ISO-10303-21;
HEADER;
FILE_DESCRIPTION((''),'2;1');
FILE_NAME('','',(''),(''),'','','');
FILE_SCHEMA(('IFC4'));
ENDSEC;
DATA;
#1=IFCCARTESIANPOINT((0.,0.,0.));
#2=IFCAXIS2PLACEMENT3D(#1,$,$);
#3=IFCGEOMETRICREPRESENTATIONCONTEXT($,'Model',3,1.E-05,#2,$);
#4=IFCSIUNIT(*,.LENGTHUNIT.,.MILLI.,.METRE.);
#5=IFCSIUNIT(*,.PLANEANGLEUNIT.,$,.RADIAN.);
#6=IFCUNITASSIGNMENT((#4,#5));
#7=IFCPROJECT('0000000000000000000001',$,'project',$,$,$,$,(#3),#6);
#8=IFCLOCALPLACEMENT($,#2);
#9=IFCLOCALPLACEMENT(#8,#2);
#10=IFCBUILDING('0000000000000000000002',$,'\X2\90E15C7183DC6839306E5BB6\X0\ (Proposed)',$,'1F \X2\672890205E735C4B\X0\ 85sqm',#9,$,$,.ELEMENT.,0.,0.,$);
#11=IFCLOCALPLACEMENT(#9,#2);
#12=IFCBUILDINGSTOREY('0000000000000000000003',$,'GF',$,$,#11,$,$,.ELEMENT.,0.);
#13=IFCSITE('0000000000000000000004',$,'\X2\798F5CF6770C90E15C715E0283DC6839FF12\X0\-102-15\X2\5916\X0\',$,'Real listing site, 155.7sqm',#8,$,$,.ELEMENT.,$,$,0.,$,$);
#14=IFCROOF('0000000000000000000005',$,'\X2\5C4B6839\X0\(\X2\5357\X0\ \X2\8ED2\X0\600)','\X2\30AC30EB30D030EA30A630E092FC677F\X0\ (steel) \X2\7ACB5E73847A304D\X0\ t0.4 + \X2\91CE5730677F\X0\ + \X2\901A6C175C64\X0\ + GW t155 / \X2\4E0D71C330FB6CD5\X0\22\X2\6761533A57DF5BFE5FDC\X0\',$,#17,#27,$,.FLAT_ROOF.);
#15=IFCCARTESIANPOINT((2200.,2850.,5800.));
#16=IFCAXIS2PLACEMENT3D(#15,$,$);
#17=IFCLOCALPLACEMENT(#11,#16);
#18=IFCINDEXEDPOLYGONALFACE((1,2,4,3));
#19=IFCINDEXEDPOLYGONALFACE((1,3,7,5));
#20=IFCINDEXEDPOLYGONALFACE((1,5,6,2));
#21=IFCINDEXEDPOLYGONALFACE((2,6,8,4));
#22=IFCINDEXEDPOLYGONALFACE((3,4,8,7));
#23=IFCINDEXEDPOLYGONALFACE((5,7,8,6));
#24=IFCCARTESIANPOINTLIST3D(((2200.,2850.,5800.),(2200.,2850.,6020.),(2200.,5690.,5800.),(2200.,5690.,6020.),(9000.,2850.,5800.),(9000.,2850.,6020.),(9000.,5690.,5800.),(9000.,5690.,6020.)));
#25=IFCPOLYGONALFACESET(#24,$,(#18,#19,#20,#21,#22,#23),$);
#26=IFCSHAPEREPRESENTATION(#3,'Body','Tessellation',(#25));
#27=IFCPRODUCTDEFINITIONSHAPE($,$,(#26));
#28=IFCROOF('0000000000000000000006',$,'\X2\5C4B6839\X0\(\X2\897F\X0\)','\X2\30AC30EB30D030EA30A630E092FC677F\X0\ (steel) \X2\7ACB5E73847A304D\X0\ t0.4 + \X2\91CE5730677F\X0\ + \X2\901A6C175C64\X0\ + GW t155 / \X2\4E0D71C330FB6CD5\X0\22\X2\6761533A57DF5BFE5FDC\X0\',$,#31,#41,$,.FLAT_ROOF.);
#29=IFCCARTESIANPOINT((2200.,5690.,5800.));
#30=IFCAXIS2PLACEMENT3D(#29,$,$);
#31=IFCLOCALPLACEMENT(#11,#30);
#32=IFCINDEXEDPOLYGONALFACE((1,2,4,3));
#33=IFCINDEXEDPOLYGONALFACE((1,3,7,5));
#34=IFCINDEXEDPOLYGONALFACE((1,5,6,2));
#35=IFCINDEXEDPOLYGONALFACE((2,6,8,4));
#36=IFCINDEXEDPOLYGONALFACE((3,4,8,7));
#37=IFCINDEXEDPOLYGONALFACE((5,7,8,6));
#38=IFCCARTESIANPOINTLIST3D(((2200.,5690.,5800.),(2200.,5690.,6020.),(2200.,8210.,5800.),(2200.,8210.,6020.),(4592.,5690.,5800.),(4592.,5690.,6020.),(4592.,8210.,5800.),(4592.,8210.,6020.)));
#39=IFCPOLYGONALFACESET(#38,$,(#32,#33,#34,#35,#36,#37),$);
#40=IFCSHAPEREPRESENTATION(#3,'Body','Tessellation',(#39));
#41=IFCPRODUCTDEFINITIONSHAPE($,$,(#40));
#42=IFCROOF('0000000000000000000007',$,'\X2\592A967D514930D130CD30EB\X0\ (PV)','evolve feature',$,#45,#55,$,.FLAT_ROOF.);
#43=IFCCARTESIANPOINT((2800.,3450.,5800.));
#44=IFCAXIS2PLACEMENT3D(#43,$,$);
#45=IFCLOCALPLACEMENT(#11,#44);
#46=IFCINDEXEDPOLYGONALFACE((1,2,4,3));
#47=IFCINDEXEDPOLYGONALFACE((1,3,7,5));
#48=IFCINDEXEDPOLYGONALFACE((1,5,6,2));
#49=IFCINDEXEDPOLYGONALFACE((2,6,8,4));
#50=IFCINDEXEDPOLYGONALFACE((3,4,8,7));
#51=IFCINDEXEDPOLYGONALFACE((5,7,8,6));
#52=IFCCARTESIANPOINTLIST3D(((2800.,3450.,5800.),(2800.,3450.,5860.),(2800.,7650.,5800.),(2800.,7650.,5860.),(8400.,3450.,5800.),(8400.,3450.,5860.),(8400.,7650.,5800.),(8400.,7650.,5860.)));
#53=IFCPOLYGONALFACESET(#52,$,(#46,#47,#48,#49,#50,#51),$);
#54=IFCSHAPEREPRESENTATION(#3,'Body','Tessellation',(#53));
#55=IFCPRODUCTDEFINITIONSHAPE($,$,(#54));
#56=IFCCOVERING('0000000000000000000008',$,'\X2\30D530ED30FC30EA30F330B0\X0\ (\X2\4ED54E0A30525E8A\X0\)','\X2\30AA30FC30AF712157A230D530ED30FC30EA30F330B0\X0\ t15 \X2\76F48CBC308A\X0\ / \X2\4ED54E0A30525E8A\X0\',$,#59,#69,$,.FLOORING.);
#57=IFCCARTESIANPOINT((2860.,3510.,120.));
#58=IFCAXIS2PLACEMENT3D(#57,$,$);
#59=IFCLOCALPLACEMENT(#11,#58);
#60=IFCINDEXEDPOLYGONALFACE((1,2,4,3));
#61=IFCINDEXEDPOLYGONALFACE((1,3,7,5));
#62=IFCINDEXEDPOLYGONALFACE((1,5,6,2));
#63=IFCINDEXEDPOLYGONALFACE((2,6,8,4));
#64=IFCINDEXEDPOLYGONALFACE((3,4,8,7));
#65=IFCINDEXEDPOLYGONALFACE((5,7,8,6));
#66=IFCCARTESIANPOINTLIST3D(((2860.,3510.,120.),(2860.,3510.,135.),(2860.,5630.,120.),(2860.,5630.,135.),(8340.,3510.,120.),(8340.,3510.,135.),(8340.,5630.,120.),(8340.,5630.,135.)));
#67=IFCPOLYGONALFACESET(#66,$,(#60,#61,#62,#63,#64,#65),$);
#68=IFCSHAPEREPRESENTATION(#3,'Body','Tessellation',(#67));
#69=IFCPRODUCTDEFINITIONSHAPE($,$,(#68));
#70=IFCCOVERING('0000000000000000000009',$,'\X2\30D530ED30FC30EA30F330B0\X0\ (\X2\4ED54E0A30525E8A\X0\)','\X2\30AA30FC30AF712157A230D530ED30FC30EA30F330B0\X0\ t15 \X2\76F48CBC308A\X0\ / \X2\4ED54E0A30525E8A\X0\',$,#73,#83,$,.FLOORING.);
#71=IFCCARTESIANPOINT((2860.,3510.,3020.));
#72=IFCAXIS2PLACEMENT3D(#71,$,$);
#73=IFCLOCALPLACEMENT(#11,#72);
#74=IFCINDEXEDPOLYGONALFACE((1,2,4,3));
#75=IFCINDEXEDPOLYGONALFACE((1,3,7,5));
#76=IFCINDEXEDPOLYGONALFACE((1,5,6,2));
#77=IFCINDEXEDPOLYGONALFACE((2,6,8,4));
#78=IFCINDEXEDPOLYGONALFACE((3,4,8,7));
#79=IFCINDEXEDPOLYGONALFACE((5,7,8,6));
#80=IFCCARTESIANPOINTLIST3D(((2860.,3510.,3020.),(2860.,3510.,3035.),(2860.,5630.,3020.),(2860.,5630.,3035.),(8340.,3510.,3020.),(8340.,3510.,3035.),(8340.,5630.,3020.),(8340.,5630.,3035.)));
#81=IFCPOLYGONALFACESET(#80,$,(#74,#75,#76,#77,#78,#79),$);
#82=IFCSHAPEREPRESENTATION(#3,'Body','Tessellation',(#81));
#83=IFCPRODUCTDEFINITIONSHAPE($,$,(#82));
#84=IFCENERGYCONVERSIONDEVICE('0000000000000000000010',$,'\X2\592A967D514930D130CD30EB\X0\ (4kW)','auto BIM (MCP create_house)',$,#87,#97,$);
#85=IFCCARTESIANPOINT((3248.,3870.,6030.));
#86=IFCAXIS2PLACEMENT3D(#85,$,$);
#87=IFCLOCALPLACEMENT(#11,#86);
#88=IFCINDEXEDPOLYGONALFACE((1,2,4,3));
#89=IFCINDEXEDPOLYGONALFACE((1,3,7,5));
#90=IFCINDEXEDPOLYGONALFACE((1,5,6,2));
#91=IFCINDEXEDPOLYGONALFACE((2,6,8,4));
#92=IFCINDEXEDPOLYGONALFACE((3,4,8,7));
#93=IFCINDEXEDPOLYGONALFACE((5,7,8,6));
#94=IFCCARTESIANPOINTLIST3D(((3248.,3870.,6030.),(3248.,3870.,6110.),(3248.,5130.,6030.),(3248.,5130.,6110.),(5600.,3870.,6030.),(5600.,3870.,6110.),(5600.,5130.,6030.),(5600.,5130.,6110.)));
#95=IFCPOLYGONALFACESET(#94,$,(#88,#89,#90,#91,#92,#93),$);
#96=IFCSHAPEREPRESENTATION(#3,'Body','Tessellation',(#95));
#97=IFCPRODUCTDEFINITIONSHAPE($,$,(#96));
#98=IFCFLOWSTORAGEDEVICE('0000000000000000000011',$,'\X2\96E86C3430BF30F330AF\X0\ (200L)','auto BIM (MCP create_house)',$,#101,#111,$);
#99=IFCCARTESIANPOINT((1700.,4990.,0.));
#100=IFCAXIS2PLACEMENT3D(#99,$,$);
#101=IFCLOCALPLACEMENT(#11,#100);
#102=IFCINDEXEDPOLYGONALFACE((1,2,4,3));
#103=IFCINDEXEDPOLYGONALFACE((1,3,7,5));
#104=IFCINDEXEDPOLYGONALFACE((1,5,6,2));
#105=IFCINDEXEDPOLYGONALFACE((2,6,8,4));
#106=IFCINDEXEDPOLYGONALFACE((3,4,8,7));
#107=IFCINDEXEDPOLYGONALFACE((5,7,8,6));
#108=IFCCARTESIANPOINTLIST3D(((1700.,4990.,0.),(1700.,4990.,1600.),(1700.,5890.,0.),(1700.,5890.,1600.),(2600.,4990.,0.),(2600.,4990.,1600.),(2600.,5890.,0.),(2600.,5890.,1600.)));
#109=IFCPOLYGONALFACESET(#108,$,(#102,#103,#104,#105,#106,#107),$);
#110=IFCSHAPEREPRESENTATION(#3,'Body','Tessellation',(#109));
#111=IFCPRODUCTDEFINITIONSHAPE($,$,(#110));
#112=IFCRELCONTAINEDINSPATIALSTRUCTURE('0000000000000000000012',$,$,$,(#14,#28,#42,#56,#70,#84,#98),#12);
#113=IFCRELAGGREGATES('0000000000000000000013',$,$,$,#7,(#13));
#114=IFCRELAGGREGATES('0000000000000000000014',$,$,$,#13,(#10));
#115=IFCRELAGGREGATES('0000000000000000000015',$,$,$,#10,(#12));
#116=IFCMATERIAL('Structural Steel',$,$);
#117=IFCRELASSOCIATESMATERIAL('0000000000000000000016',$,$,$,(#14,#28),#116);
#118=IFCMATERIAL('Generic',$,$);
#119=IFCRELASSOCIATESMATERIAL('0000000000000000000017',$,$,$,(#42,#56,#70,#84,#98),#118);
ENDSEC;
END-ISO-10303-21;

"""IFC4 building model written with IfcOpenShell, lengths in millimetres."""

from ifc_helpers import new_model, si_unit, frame, frame_2d, origin, place, context, project, spatial, rectangle, extrude, material, element, save


model = new_model("IFC4")

# Units and contexts
model_context = context("Model", 3, precision=1e-05, world=origin())
ifc_project = project(units=[si_unit("LENGTHUNIT", "METRE", prefix="MILLI"), si_unit("PLANEANGLEUNIT", "RADIAN")], contexts=[model_context])

# Site, building, storey
site_placement = place(None, origin())
site = spatial("IfcSite", under=ifc_project, at=site_placement, Name="福島県郡山市菜根２-102-15外", ObjectType="Real listing site, 155.7sqm", CompositionType="ELEMENT", RefElevation=0.0)
building_placement = place(site_placement, origin())
building = spatial("IfcBuilding", under=site, at=building_placement, Name="郡山菜根の家 (Proposed)", ObjectType="1F 木造平屋 85sqm", CompositionType="ELEMENT", ElevationOfRefHeight=0.0, ElevationOfTerrain=0.0)
storey_placement = place(building_placement, origin())
storey = spatial("IfcBuildingStorey", under=building, at=storey_placement, Name="GF", CompositionType="ELEMENT", Elevation=0.0)

# Shared definitions
ifc_material_1 = material(Name="Generic")

# Roofs
ifc_material_2 = material(Name="Structural Steel")
roof_1_placement = place(storey_placement, frame((2200.0, 2850.0, 5800.0)))
element("IfcRoof", 1, at=roof_1_placement, inside=storey, material=ifc_material_2, Name="屋根(南 軒600)", Description="ガルバリウム鋼板 (steel) 立平葺き t0.4 + 野地板 + 通気層 + GW t155 / 不燃・法22条区域対応", PredefinedType="FLAT_ROOF", context=model_context, shape_type="SweptSolid", body=[
    extrude(rectangle(XDim=6800.0, YDim=2840.0, at=frame_2d((3400.0, 1420.0))), frame((2200.0, 2850.0, 5800.0)), (0.0, 0.0, 1.0), 220.0),
])
roof_2_placement = place(storey_placement, frame((2200.0, 5690.0, 5800.0)))
element("IfcRoof", 2, at=roof_2_placement, inside=storey, material=ifc_material_2, Name="屋根(西)", Description="ガルバリウム鋼板 (steel) 立平葺き t0.4 + 野地板 + 通気層 + GW t155 / 不燃・法22条区域対応", PredefinedType="FLAT_ROOF", context=model_context, shape_type="SweptSolid", body=[
    extrude(rectangle(XDim=2392.0, YDim=2520.0, at=frame_2d((1196.0, 1260.0))), frame((2200.0, 5690.0, 5800.0)), (0.0, 0.0, 1.0), 220.0),
])
roof_3_placement = place(storey_placement, frame((2800.0, 3450.0, 5800.0)))
element("IfcRoof", 3, at=roof_3_placement, inside=storey, material=ifc_material_1, Name="太陽光パネル (PV)", Description="evolve feature", PredefinedType="FLAT_ROOF", context=model_context, shape_type="SweptSolid", body=[
    extrude(rectangle(XDim=5600.0, YDim=4200.0, at=frame_2d((2800.0, 2100.0))), frame((2800.0, 3450.0, 5800.0)), (0.0, 0.0, 1.0), 60.0),
])

# Coverings
covering_1_placement = place(storey_placement, frame((2860.0, 3510.0, 120.0)))
element("IfcCovering", 4, at=covering_1_placement, inside=storey, material=ifc_material_1, Name="フローリング (仕上げ床)", Description="オーク無垢フローリング t15 直貼り / 仕上げ床", PredefinedType="FLOORING", context=model_context, shape_type="SweptSolid", body=[
    extrude(rectangle(XDim=5480.0, YDim=2120.0, at=frame_2d((2740.0, 1060.0))), frame((2860.0, 3510.0, 120.0)), (0.0, 0.0, 1.0), 15.0),
])
covering_2_placement = place(storey_placement, frame((2860.0, 3510.0, 3020.0)))
element("IfcCovering", 5, at=covering_2_placement, inside=storey, material=ifc_material_1, Name="フローリング (仕上げ床)", Description="オーク無垢フローリング t15 直貼り / 仕上げ床", PredefinedType="FLOORING", context=model_context, shape_type="SweptSolid", body=[
    extrude(rectangle(XDim=5480.0, YDim=2120.0, at=frame_2d((2740.0, 1060.0))), frame((2860.0, 3510.0, 3020.0)), (0.0, 0.0, 1.0), 15.0),
])

# Energy conversion device
energy_conversion_device_placement = place(storey_placement, frame((3248.0, 3870.0, 6030.0)))
element("IfcEnergyConversionDevice", 6, at=energy_conversion_device_placement, inside=storey, material=ifc_material_1, Name="太陽光パネル (4kW)", Description="auto BIM (MCP create_house)", context=model_context, shape_type="SweptSolid", body=[
    extrude(rectangle(XDim=2352.0, YDim=1260.0, at=frame_2d((1176.0, 630.0))), frame((3248.0, 3870.0, 6030.0)), (0.0, 0.0, 1.0), 80.0),
])

# Flow storage device
flow_storage_device_placement = place(storey_placement, frame((1700.0, 4990.0, 0.0)))
element("IfcFlowStorageDevice", 7, at=flow_storage_device_placement, inside=storey, material=ifc_material_1, Name="雨水タンク (200L)", Description="auto BIM (MCP create_house)", context=model_context, shape_type="SweptSolid", body=[
    extrude(rectangle(XDim=900.0, YDim=900.0, at=frame_2d((450.0, 450.0))), frame((1700.0, 4990.0, 0.0)), (0.0, 0.0, 1.0), 1600.0),
])

save(model, "model.ifc")
